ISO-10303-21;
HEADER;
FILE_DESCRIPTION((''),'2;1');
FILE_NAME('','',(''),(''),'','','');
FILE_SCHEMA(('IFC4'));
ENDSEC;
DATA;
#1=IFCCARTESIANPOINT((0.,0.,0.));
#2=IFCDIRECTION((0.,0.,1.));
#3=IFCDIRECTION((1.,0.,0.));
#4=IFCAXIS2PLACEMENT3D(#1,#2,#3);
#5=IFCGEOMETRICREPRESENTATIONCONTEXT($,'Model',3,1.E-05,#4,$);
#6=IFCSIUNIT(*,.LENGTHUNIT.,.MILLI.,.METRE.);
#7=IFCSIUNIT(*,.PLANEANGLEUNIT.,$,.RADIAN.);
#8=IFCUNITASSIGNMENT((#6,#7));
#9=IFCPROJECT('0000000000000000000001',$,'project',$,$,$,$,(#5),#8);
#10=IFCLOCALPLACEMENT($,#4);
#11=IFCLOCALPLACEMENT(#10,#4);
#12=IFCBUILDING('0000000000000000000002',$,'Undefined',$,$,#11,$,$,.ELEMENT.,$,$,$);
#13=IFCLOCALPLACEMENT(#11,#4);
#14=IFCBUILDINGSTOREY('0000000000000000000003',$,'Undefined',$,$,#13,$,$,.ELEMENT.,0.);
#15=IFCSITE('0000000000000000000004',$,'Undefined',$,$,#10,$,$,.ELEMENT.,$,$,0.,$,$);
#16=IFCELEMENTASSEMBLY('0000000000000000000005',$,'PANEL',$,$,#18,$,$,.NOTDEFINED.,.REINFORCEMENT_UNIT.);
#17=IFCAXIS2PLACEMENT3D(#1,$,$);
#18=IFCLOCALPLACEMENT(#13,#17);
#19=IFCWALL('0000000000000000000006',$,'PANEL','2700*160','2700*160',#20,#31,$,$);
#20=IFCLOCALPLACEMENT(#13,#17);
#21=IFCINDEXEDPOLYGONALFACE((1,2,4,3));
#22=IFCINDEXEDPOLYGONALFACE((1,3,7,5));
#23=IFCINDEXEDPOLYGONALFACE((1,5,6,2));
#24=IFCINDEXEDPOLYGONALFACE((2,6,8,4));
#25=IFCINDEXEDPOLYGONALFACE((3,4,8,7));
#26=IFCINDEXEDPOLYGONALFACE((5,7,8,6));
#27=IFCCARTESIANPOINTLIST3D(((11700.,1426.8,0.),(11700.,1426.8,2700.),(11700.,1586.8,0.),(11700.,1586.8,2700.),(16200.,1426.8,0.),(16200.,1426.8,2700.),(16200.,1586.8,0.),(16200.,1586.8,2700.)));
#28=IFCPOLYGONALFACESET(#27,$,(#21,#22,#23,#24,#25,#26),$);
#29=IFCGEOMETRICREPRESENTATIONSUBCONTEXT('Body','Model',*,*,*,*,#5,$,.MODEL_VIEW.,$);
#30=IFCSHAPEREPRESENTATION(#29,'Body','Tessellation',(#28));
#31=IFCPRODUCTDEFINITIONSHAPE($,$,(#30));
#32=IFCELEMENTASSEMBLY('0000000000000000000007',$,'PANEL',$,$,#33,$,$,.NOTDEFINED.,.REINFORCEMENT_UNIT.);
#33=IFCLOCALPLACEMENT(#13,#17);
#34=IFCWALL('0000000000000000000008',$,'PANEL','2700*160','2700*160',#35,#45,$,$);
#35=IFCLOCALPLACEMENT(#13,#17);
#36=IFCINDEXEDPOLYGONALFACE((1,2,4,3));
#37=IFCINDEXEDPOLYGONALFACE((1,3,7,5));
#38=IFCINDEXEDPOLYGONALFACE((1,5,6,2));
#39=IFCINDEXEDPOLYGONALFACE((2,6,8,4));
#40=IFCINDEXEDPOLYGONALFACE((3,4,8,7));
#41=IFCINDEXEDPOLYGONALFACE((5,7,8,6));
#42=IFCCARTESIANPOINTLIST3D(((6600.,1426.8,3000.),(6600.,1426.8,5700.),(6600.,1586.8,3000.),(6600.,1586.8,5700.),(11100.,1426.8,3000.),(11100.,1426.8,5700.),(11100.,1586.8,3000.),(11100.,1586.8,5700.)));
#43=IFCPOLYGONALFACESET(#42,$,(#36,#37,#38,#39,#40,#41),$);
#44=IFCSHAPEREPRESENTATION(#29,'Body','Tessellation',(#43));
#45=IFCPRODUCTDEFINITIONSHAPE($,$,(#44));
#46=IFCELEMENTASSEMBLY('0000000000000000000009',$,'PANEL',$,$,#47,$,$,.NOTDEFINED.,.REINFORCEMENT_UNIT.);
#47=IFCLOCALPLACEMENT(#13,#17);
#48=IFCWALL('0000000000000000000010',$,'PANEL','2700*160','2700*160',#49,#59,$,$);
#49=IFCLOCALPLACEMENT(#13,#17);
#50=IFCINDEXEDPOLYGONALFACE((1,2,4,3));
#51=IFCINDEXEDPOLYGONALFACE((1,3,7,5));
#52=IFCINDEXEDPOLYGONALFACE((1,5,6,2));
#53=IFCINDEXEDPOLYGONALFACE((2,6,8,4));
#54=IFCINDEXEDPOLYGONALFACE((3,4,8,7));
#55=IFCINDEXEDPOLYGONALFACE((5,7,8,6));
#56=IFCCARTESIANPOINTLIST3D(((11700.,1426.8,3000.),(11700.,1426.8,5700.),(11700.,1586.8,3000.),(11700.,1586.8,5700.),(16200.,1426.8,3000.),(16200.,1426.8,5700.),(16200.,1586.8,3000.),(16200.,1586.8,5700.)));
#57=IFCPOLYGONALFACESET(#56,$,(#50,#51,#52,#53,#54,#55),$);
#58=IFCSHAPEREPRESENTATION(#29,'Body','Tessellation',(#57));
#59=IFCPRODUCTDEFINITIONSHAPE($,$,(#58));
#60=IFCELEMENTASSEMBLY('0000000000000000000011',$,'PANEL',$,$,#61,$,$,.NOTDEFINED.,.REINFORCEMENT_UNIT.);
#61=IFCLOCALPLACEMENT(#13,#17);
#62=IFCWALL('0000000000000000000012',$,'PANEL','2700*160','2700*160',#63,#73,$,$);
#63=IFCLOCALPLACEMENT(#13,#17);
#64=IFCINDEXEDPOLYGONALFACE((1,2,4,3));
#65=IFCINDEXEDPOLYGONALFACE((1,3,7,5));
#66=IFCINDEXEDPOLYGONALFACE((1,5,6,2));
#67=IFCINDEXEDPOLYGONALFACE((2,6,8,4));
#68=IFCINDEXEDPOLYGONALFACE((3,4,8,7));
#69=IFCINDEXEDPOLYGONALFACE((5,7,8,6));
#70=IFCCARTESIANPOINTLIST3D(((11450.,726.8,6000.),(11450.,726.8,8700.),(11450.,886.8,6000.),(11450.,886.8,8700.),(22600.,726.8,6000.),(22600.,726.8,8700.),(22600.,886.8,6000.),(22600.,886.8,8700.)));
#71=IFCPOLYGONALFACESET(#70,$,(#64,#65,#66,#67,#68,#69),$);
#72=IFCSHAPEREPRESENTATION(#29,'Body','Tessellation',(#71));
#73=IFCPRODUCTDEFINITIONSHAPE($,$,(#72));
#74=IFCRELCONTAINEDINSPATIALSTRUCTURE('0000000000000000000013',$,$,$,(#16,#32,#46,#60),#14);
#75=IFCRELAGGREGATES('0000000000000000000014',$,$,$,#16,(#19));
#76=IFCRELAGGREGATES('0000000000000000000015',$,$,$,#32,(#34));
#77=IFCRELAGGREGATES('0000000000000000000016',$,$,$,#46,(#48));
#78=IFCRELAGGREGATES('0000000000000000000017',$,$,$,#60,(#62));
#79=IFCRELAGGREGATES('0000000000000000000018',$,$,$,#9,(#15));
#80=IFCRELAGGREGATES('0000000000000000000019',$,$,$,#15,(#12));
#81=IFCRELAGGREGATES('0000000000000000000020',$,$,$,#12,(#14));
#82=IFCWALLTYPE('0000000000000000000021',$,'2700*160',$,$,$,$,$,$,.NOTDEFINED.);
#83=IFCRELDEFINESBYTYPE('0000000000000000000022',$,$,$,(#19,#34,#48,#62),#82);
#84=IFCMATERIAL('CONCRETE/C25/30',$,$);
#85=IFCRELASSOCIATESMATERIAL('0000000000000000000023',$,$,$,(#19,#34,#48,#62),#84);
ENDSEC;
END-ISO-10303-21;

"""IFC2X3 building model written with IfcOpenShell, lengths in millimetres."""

from ifc_helpers import new_model, si_unit, frame, frame_2d, origin_with_axes, place, context, subcontext, project, spatial, rectangle, extrude, material, type_object, element, aggregate, save


model = new_model("IFC2X3")

# Units and contexts
model_context = context("Model", 3, precision=1e-05, world=origin_with_axes())
body_context = subcontext(model_context, "Body", "Model", "MODEL_VIEW")
ifc_project = project(units=[si_unit("LENGTHUNIT", "METRE", prefix="MILLI"), si_unit("PLANEANGLEUNIT", "RADIAN")], contexts=[model_context])

# Site, building, storey
site_placement = place(None, origin_with_axes())
site = spatial("IfcSite", under=ifc_project, at=site_placement, Name="Undefined", CompositionType="ELEMENT", RefElevation=0.0)
building_placement = place(site_placement, origin_with_axes())
building = spatial("IfcBuilding", under=site, at=building_placement, Name="Undefined", CompositionType="ELEMENT")
storey_placement = place(building_placement, origin_with_axes())
storey = spatial("IfcBuildingStorey", under=building, at=storey_placement, Name="Undefined", CompositionType="ELEMENT", Elevation=0.0)

# Shared definitions
ifc_material = material(Name="CONCRETE/C25/30")

# Element assemblies, walls
wall_type = type_object("IfcWallType", Name="2700*160", PredefinedType="NOTDEFINED")
assembly_1_placement = place(storey_placement, origin_with_axes())
assembly_1 = element("IfcElementAssembly", 1, at=assembly_1_placement, inside=storey, Name="PANEL", AssemblyPlace="NOTDEFINED", PredefinedType="REINFORCEMENT_UNIT")
wall_1_placement = place(assembly_1_placement, frame((11700.0, 1506.8, 0.0), z_axis=(0.0, 0.0, 1.0), x_axis=(1.0, 0.0, 0.0)))
wall_1 = element("IfcWall", 2, at=wall_1_placement, type_object=wall_type, material=ifc_material, Name="PANEL", Description="2700*160", ObjectType="2700*160", context=body_context, shape_type="SweptSolid", body=[
    extrude(rectangle(XDim=4500.0, YDim=160.0, at=frame_2d((0.0, 2250.0), x_axis=(0.0, -1.0))), frame((0.0, 0.0, 0.0), z_axis=(0.0, 0.0, 1.0), x_axis=(0.0, -1.0, 0.0)), (0.0, 0.0, 1.0), 2700.0),
])
aggregate(assembly_1, [wall_1])
assembly_2_placement = place(storey_placement, origin_with_axes())
assembly_2 = element("IfcElementAssembly", 3, at=assembly_2_placement, inside=storey, Name="PANEL", AssemblyPlace="NOTDEFINED", PredefinedType="REINFORCEMENT_UNIT")
wall_2_placement = place(assembly_2_placement, frame((6600.0, 1506.8, 3000.0), z_axis=(0.0, 0.0, 1.0), x_axis=(1.0, 0.0, 0.0)))
wall_2 = element("IfcWall", 4, at=wall_2_placement, type_object=wall_type, material=ifc_material, Name="PANEL", Description="2700*160", ObjectType="2700*160", context=body_context, shape_type="SweptSolid", body=[
    extrude(rectangle(XDim=4500.0, YDim=160.0, at=frame_2d((0.0, 2250.0), x_axis=(0.0, -1.0))), frame((0.0, 0.0, 0.0), z_axis=(0.0, 0.0, 1.0), x_axis=(0.0, -1.0, 0.0)), (0.0, 0.0, 1.0), 2700.0),
])
aggregate(assembly_2, [wall_2])
assembly_3_placement = place(storey_placement, origin_with_axes())
assembly_3 = element("IfcElementAssembly", 5, at=assembly_3_placement, inside=storey, Name="PANEL", AssemblyPlace="NOTDEFINED", PredefinedType="REINFORCEMENT_UNIT")
wall_3_placement = place(assembly_3_placement, frame((11700.0, 1506.8, 3000.0), z_axis=(0.0, 0.0, 1.0), x_axis=(1.0, 0.0, 0.0)))
wall_3 = element("IfcWall", 6, at=wall_3_placement, type_object=wall_type, material=ifc_material, Name="PANEL", Description="2700*160", ObjectType="2700*160", context=body_context, shape_type="SweptSolid", body=[
    extrude(rectangle(XDim=4500.0, YDim=160.0, at=frame_2d((0.0, 2250.0), x_axis=(0.0, -1.0))), frame((0.0, 0.0, 0.0), z_axis=(0.0, 0.0, 1.0), x_axis=(0.0, -1.0, 0.0)), (0.0, 0.0, 1.0), 2700.0),
])
aggregate(assembly_3, [wall_3])
assembly_4_placement = place(storey_placement, origin_with_axes())
assembly_4 = element("IfcElementAssembly", 7, at=assembly_4_placement, inside=storey, Name="PANEL", AssemblyPlace="NOTDEFINED", PredefinedType="REINFORCEMENT_UNIT")
wall_4_placement = place(assembly_4_placement, frame((11450.0, 806.8, 6000.0), z_axis=(0.0, 0.0, 1.0), x_axis=(1.0, 0.0, 0.0)))
wall_4 = element("IfcWall", 8, at=wall_4_placement, type_object=wall_type, material=ifc_material, Name="PANEL", Description="2700*160", ObjectType="2700*160", context=body_context, shape_type="SweptSolid", body=[
    extrude(rectangle(XDim=11150.0, YDim=160.0, at=frame_2d((0.0, 5575.0), x_axis=(0.0, -1.0))), frame((0.0, 0.0, 0.0), z_axis=(0.0, 0.0, 1.0), x_axis=(0.0, -1.0, 0.0)), (0.0, 0.0, 1.0), 2700.0),
])
aggregate(assembly_4, [wall_4])

save(model, "model.ifc")
